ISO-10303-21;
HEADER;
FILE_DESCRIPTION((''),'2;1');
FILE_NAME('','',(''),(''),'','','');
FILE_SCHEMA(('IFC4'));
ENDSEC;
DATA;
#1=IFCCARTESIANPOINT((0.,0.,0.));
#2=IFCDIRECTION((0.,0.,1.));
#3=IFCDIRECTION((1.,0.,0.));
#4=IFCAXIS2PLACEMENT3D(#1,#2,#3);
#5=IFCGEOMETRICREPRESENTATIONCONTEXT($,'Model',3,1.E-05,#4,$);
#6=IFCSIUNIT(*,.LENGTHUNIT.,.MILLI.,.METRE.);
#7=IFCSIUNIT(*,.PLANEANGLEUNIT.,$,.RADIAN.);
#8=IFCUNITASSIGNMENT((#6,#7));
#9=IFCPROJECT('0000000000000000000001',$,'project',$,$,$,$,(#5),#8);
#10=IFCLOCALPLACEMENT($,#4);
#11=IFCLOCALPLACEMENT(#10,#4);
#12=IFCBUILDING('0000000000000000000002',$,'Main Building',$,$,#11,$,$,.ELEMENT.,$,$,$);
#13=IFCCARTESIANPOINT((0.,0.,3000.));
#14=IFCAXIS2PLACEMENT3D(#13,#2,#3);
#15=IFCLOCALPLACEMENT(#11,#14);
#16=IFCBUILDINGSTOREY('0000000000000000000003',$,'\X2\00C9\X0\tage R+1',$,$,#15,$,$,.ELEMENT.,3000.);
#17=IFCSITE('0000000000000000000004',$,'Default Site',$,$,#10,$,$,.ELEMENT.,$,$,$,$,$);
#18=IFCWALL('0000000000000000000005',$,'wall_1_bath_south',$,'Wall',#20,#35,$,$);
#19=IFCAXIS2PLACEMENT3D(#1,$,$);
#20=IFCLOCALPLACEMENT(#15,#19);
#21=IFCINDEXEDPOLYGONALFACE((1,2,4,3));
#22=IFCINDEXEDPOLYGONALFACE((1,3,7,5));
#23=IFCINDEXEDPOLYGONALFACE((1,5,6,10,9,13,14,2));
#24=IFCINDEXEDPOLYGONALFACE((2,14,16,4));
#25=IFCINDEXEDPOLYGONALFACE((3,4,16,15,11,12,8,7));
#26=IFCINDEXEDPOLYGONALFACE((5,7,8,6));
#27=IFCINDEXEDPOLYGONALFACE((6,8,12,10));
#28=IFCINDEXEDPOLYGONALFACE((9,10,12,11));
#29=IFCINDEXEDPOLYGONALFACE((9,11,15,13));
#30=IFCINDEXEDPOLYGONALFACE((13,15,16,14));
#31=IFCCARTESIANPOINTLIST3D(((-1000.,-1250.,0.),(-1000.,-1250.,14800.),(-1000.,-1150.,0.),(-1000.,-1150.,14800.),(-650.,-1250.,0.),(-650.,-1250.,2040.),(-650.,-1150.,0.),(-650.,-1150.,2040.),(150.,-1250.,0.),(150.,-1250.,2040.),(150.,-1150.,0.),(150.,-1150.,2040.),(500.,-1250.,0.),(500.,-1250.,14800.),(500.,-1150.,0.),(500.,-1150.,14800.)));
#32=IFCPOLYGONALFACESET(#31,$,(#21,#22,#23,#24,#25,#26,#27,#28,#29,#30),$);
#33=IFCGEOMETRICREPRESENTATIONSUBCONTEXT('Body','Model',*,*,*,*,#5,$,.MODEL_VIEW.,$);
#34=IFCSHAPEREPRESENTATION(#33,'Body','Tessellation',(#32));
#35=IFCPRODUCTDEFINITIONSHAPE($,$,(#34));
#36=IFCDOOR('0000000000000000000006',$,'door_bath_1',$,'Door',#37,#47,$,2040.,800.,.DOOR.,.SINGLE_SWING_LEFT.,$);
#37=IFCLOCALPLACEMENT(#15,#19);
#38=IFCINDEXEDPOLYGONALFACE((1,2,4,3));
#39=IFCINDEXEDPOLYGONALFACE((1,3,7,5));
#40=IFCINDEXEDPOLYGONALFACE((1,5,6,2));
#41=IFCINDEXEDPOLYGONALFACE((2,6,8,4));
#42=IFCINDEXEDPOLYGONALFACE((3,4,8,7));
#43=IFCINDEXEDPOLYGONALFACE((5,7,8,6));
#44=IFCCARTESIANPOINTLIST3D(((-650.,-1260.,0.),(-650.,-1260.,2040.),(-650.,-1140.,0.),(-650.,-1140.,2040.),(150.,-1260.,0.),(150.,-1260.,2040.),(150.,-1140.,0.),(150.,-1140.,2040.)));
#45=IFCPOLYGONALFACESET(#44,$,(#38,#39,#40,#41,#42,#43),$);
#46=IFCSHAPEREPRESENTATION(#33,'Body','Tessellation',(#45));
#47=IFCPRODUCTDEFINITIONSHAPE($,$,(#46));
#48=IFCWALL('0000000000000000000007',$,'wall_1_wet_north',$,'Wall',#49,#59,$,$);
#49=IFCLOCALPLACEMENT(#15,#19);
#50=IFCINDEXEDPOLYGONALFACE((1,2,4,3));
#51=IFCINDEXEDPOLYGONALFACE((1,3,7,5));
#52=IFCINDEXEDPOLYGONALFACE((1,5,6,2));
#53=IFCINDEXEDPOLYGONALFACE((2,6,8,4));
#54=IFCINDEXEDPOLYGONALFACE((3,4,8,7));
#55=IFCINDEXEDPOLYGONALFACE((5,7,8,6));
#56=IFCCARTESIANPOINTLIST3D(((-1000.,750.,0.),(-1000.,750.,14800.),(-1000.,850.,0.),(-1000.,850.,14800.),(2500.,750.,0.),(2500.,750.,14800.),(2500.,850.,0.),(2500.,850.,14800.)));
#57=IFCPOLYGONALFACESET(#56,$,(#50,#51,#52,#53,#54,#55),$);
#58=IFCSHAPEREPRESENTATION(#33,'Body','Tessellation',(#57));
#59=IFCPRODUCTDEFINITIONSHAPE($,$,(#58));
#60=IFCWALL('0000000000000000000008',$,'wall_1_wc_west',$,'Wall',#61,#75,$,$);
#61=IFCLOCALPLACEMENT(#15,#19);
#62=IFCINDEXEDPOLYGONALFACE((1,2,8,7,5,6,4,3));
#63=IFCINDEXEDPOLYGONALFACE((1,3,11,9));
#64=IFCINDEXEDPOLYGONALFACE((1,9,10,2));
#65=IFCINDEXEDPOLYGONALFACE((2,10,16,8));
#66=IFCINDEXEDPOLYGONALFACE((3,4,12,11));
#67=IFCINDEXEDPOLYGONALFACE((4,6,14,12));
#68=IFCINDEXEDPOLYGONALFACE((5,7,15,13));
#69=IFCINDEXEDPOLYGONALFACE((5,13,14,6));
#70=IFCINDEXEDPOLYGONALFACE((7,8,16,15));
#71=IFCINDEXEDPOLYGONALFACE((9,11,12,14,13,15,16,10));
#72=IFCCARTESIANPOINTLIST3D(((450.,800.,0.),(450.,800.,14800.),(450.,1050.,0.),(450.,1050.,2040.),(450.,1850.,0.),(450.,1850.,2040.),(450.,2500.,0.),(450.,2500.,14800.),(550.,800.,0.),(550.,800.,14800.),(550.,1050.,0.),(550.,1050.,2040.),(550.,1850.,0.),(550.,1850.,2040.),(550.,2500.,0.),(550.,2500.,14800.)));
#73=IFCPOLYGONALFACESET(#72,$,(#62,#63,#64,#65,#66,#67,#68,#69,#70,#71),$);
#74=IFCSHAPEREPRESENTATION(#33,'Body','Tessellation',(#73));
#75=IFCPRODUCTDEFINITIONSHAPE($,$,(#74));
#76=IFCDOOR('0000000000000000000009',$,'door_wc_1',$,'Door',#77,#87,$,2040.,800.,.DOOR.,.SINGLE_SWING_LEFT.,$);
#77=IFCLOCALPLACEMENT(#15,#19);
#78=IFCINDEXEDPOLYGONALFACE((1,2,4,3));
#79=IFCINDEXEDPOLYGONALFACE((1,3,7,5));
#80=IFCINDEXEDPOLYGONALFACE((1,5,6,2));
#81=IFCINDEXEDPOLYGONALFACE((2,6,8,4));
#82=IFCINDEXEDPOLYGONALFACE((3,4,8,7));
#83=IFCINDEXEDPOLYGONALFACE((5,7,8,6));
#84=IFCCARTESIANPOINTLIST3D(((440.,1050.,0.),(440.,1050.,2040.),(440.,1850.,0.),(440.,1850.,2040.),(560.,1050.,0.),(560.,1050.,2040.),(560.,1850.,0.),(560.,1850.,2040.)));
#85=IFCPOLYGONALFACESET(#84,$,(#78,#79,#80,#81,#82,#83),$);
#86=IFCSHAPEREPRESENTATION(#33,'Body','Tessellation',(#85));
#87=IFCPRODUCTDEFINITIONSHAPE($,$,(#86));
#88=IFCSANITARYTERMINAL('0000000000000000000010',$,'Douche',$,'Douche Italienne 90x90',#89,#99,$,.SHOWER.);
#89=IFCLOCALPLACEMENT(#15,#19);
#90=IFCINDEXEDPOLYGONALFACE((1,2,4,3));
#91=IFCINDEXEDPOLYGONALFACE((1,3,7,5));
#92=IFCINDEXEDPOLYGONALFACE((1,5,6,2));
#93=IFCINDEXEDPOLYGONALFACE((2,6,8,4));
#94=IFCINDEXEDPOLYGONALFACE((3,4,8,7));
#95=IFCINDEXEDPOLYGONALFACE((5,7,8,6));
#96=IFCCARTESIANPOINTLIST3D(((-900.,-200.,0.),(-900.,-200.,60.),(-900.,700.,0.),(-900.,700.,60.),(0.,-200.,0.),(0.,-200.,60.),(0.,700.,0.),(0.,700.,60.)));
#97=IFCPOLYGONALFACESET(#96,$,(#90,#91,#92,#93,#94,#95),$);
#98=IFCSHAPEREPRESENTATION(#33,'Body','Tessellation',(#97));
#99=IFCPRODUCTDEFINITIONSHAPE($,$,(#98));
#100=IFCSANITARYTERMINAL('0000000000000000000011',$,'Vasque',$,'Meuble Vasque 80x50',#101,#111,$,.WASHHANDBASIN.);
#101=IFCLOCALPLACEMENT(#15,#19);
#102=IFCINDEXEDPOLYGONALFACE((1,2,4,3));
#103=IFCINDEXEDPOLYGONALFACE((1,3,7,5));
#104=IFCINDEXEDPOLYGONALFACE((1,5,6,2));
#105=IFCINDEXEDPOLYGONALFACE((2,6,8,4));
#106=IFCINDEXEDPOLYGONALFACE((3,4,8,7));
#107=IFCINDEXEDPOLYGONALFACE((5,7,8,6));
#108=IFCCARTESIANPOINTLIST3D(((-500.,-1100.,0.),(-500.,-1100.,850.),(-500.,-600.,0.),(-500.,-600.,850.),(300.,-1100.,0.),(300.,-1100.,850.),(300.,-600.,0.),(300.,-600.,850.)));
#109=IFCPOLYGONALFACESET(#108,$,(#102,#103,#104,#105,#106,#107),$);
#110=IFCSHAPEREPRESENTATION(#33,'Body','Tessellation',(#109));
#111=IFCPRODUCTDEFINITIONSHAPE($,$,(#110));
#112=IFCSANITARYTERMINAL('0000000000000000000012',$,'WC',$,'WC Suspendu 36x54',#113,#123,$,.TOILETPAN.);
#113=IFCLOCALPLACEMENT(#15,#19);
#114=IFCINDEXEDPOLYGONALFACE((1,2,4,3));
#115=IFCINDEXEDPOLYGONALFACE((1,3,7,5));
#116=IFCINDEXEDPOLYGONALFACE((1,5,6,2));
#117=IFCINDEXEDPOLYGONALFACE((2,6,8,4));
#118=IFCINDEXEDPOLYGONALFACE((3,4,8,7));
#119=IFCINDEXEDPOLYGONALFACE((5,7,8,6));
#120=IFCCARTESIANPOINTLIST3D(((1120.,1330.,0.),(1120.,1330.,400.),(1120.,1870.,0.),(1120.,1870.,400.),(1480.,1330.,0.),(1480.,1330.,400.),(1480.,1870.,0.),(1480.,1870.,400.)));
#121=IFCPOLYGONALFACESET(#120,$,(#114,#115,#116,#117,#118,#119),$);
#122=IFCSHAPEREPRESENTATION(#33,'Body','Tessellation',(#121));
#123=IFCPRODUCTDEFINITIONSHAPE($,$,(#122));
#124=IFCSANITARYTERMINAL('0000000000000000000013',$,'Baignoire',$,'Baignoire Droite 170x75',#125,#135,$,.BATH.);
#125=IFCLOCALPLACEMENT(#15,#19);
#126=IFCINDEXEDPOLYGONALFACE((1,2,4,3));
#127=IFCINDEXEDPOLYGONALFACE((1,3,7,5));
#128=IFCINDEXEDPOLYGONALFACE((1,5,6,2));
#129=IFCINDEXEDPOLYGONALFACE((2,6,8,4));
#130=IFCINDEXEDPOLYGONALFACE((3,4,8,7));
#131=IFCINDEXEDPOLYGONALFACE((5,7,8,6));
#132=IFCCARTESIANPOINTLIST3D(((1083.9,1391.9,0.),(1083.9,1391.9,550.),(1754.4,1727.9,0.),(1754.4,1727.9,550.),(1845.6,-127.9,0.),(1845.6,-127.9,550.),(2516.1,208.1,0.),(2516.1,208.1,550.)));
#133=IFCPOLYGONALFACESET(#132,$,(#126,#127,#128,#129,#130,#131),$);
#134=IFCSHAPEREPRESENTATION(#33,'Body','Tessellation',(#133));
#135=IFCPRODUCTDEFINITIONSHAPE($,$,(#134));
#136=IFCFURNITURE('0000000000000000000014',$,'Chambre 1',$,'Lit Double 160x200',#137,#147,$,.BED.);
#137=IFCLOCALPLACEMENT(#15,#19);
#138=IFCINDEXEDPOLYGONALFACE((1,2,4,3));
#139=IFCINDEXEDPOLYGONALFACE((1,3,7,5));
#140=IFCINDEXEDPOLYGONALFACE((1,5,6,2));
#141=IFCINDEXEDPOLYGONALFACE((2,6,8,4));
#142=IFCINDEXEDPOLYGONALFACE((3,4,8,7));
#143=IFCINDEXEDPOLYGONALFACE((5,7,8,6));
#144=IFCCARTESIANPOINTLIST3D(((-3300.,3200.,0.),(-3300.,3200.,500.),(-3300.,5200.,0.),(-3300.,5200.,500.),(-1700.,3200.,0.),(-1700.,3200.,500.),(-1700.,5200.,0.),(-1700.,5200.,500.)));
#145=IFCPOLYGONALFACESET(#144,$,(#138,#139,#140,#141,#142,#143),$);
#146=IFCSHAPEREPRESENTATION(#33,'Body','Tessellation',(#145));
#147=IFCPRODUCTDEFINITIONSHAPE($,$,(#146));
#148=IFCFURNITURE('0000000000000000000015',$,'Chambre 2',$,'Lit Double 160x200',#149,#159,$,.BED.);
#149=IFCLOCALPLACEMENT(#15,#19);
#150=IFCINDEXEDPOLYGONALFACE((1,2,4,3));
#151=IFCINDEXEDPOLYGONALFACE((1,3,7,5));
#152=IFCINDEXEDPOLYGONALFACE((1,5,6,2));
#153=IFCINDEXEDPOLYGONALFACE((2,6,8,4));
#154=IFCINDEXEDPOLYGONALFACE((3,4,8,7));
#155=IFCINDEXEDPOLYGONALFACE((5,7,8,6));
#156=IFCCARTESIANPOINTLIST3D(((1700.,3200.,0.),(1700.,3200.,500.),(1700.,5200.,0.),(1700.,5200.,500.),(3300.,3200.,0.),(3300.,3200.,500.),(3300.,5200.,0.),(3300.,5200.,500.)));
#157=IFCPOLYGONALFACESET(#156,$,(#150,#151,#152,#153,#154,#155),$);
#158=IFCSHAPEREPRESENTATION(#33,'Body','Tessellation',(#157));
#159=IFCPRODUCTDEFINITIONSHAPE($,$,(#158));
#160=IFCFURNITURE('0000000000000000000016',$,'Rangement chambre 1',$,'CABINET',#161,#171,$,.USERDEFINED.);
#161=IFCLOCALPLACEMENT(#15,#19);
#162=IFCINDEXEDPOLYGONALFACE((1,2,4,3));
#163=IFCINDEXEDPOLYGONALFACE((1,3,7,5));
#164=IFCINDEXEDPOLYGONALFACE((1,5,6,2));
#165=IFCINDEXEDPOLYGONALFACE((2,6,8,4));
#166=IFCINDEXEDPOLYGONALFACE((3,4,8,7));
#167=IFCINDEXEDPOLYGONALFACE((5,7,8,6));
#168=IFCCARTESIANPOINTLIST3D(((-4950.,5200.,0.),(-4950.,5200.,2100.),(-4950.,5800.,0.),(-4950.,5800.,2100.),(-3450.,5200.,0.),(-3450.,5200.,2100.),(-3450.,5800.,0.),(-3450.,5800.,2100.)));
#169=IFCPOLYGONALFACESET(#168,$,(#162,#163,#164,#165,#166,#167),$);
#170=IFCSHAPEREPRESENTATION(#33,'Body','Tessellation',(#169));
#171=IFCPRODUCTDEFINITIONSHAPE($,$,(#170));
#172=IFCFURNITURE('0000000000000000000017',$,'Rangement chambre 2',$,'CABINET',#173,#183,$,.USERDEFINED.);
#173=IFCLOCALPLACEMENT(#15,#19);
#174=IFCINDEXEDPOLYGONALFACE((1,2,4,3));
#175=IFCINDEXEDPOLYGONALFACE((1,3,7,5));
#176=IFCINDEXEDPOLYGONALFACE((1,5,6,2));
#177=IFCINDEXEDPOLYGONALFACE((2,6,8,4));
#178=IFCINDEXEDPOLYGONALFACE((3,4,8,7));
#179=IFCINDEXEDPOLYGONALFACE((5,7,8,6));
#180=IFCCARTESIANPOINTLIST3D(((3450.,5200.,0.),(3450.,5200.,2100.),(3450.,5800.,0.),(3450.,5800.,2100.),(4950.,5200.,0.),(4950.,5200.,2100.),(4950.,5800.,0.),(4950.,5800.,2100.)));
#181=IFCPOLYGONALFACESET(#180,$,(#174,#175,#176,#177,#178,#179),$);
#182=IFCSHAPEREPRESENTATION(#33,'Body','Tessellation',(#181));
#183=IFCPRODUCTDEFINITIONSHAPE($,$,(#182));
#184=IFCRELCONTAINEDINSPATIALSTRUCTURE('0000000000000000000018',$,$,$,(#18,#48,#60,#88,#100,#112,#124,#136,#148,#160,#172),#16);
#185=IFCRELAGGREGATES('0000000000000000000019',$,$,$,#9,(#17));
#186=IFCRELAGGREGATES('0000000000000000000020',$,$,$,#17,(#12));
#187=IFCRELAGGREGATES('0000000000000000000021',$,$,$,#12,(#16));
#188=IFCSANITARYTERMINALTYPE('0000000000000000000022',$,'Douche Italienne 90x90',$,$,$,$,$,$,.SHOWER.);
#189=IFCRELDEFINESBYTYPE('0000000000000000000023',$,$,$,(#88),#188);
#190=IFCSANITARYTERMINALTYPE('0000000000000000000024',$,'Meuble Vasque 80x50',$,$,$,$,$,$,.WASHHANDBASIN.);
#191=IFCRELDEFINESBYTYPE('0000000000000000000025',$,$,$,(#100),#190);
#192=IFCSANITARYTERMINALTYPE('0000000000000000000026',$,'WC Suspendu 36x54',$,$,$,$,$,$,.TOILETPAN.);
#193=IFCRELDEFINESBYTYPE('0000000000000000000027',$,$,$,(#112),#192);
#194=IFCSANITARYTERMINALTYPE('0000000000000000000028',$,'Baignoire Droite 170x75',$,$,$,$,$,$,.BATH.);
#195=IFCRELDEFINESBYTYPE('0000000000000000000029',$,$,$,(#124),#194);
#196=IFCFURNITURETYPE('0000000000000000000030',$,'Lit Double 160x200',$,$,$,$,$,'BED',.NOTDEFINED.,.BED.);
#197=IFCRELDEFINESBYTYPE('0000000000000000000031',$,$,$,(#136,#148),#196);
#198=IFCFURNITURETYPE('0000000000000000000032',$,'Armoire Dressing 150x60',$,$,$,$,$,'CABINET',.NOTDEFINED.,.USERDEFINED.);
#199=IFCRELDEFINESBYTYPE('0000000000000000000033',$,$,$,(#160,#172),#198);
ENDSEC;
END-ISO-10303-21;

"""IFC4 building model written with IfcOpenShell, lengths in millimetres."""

from ifc_helpers import new_model, si_unit, frame, origin_with_axes, place, context, subcontext, project, spatial, polyline, outline, extrude, type_object, element, fill, save


model = new_model("IFC4")

# Units and contexts
model_context = context("Model", 3, precision=1e-05, world=origin_with_axes())
body_context = subcontext(model_context, "Body", "Model", "MODEL_VIEW")
ifc_project = project(units=[si_unit("LENGTHUNIT", "METRE", prefix="MILLI"), si_unit("PLANEANGLEUNIT", "RADIAN")], contexts=[model_context])

# Site, building, storey
site_placement = place(None, origin_with_axes())
site = spatial("IfcSite", under=ifc_project, at=site_placement, Name="Default Site", CompositionType="ELEMENT")
building_placement = place(site_placement, origin_with_axes())
building = spatial("IfcBuilding", under=site, at=building_placement, Name="Main Building", CompositionType="ELEMENT")
storey_placement = place(building_placement, frame((0.0, 0.0, 3000.0), z_axis=(0.0, 0.0, 1.0), x_axis=(1.0, 0.0, 0.0)))
storey = spatial("IfcBuildingStorey", under=building, at=storey_placement, Name="Étage R+1", CompositionType="ELEMENT", Elevation=3000.0)

# Wall, opening, door
wall_1_placement = place(storey_placement, frame((-1000.0, -1200.0, 0.0), z_axis=(0.0, 0.0, 1.0), x_axis=(1.0, 0.0, 0.0)))
wall_1 = element("IfcWall", 1, at=wall_1_placement, inside=storey, Name="wall_1_bath_south", ObjectType="Wall", context=body_context, shape_type="SweptSolid", body=[
    extrude(outline(polyline([(0.0, -50.0), (1500.0, -50.0), (1500.0, 50.0), (0.0, 50.0), (0.0, -50.0)])), origin_with_axes(), (0.0, 0.0, 1.0), 14800.0),
])
placement_1 = place(wall_1_placement, frame((350.0, 0.0, 0.0), z_axis=(0.0, 0.0, 1.0), x_axis=(1.0, 0.0, 0.0)))
opening_1 = element("IfcOpeningElement", 2, at=placement_1, cuts=wall_1, PredefinedType="OPENING", context=body_context, shape_type="SweptSolid", body=[
    extrude(outline(polyline([(0.0, -60.0), (800.0, -60.0), (800.0, 60.0), (0.0, 60.0), (0.0, -60.0)])), origin_with_axes(), (0.0, 0.0, 1.0), 2040.0),
])
door_1 = element("IfcDoor", 3, at=placement_1, Name="door_bath_1", ObjectType="Door", OperationType="SINGLE_SWING_LEFT", OverallHeight=2040.0, OverallWidth=800.0, PredefinedType="DOOR", context=body_context, shape_type="SweptSolid", body=[
    extrude(outline(polyline([(0.0, -60.0), (800.0, -60.0), (800.0, 60.0), (0.0, 60.0), (0.0, -60.0)])), origin_with_axes(), (0.0, 0.0, 1.0), 2040.0),
])
fill(opening_1, door_1)

# Wall
wall_2_placement = place(storey_placement, frame((-1000.0, 800.0, 0.0), z_axis=(0.0, 0.0, 1.0), x_axis=(1.0, 0.0, 0.0)))
element("IfcWall", 4, at=wall_2_placement, inside=storey, Name="wall_1_wet_north", ObjectType="Wall", context=body_context, shape_type="SweptSolid", body=[
    extrude(outline(polyline([(0.0, -50.0), (3500.0, -50.0), (3500.0, 50.0), (0.0, 50.0), (0.0, -50.0)])), origin_with_axes(), (0.0, 0.0, 1.0), 14800.0),
])

# Wall, opening, door
wall_3_placement = place(storey_placement, frame((500.0, 800.0, 0.0), z_axis=(0.0, 0.0, 1.0), x_axis=(0.0, 1.0, 0.0)))
wall_3 = element("IfcWall", 5, at=wall_3_placement, inside=storey, Name="wall_1_wc_west", ObjectType="Wall", context=body_context, shape_type="SweptSolid", body=[
    extrude(outline(polyline([(0.0, -50.0), (1700.0, -50.0), (1700.0, 50.0), (0.0, 50.0), (0.0, -50.0)])), origin_with_axes(), (0.0, 0.0, 1.0), 14800.0),
])
placement_2 = place(wall_3_placement, frame((250.0, 0.0, 0.0), z_axis=(0.0, 0.0, 1.0), x_axis=(1.0, 0.0, 0.0)))
opening_2 = element("IfcOpeningElement", 6, at=placement_2, cuts=wall_3, PredefinedType="OPENING", context=body_context, shape_type="SweptSolid", body=[
    extrude(outline(polyline([(0.0, -60.0), (800.0, -60.0), (800.0, 60.0), (0.0, 60.0), (0.0, -60.0)])), origin_with_axes(), (0.0, 0.0, 1.0), 2040.0),
])
door_2 = element("IfcDoor", 7, at=placement_2, Name="door_wc_1", ObjectType="Door", OperationType="SINGLE_SWING_LEFT", OverallHeight=2040.0, OverallWidth=800.0, PredefinedType="DOOR", context=body_context, shape_type="SweptSolid", body=[
    extrude(outline(polyline([(0.0, -60.0), (800.0, -60.0), (800.0, 60.0), (0.0, 60.0), (0.0, -60.0)])), origin_with_axes(), (0.0, 0.0, 1.0), 2040.0),
])
fill(opening_2, door_2)

# Sanitary terminals
sanitary_terminal_type_1 = type_object("IfcSanitaryTerminalType", Name="Douche Italienne 90x90", PredefinedType="SHOWER")
sanitary_terminal_1_placement = place(storey_placement, frame((-450.0, 250.0, 0.0), z_axis=(0.0, 0.0, 1.0), x_axis=(1.0, 0.0, 0.0)))
element("IfcSanitaryTerminal", 8, at=sanitary_terminal_1_placement, inside=storey, type_object=sanitary_terminal_type_1, Name="Douche", ObjectType="Douche Italienne 90x90", PredefinedType="SHOWER", context=body_context, shape_type="SweptSolid", body=[
    extrude(outline(polyline([(-450.0, -450.0), (450.0, -450.0), (450.0, 450.0), (-450.0, 450.0), (-450.0, -450.0)])), origin_with_axes(), (0.0, 0.0, 1.0), 60.0),
])
sanitary_terminal_type_2 = type_object("IfcSanitaryTerminalType", Name="Meuble Vasque 80x50", PredefinedType="WASHHANDBASIN")
sanitary_terminal_2_placement = place(storey_placement, frame((-100.0, -850.0, 0.0), z_axis=(0.0, 0.0, 1.0), x_axis=(1.0, 0.0, 0.0)))
element("IfcSanitaryTerminal", 9, at=sanitary_terminal_2_placement, inside=storey, type_object=sanitary_terminal_type_2, Name="Vasque", ObjectType="Meuble Vasque 80x50", PredefinedType="WASHHANDBASIN", context=body_context, shape_type="SweptSolid", body=[
    extrude(outline(polyline([(-400.0, -250.0), (400.0, -250.0), (400.0, 250.0), (-400.0, 250.0), (-400.0, -250.0)])), origin_with_axes(), (0.0, 0.0, 1.0), 850.0),
])
sanitary_terminal_type_3 = type_object("IfcSanitaryTerminalType", Name="WC Suspendu 36x54", PredefinedType="TOILETPAN")
sanitary_terminal_3_placement = place(storey_placement, frame((1300.0, 1600.0, 0.0), z_axis=(0.0, 0.0, 1.0), x_axis=(1.0, 0.0, 0.0)))
element("IfcSanitaryTerminal", 10, at=sanitary_terminal_3_placement, inside=storey, type_object=sanitary_terminal_type_3, Name="WC", ObjectType="WC Suspendu 36x54", PredefinedType="TOILETPAN", context=body_context, shape_type="SweptSolid", body=[
    extrude(outline(polyline([(-180.0, -270.0), (180.0, -270.0), (180.0, 270.0), (-180.0, 270.0), (-180.0, -270.0)])), origin_with_axes(), (0.0, 0.0, 1.0), 400.0),
])
sanitary_terminal_type_4 = type_object("IfcSanitaryTerminalType", Name="Baignoire Droite 170x75", PredefinedType="BATH")
sanitary_terminal_4_placement = place(storey_placement, frame((1800.0, 800.0, 0.0), z_axis=(0.0, 0.0, 1.0), x_axis=(-0.448074, 0.893997, 0.0)))
element("IfcSanitaryTerminal", 11, at=sanitary_terminal_4_placement, inside=storey, type_object=sanitary_terminal_type_4, Name="Baignoire", ObjectType="Baignoire Droite 170x75", PredefinedType="BATH", context=body_context, shape_type="SweptSolid", body=[
    extrude(outline(polyline([(-850.0, -375.0), (850.0, -375.0), (850.0, 375.0), (-850.0, 375.0), (-850.0, -375.0)])), origin_with_axes(), (0.0, 0.0, 1.0), 550.0),
])

# Furniture
furniture_type_1 = type_object("IfcFurnitureType", Name="Lit Double 160x200", ElementType="BED", AssemblyPlace="NOTDEFINED", PredefinedType="BED")
for number, where, z_axis, x_axis, name in (
    (12, (-2500.0, 4200.0, 0.0), (0.0, 0.0, 1.0), (1.0, 0.0, 0.0), "Chambre 1"),
    (13, (2500.0, 4200.0, 0.0), (0.0, 0.0, 1.0), (1.0, 0.0, 0.0), "Chambre 2"),
):
    element("IfcFurniture", number, at=place(storey_placement, frame(where, z_axis=z_axis, x_axis=x_axis)), inside=storey, type_object=furniture_type_1, Name=name, ObjectType="Lit Double 160x200", PredefinedType="BED", context=body_context, shape_type="SweptSolid", body=[
        extrude(outline(polyline([(-800.0, -1000.0), (800.0, -1000.0), (800.0, 1000.0), (-800.0, 1000.0), (-800.0, -1000.0)])), origin_with_axes(), (0.0, 0.0, 1.0), 500.0),
    ])
furniture_type_2 = type_object("IfcFurnitureType", Name="Armoire Dressing 150x60", ElementType="CABINET", AssemblyPlace="NOTDEFINED", PredefinedType="USERDEFINED")
for number, where, z_axis, x_axis, name in (
    (14, (-4200.0, 5500.0, 0.0), (0.0, 0.0, 1.0), (1.0, 0.0, 0.0), "Rangement chambre 1"),
    (15, (4200.0, 5500.0, 0.0), (0.0, 0.0, 1.0), (1.0, 0.0, 0.0), "Rangement chambre 2"),
):
    element("IfcFurniture", number, at=place(storey_placement, frame(where, z_axis=z_axis, x_axis=x_axis)), inside=storey, type_object=furniture_type_2, Name=name, ObjectType="CABINET", PredefinedType="USERDEFINED", context=body_context, shape_type="SweptSolid", body=[
        extrude(outline(polyline([(-750.0, -300.0), (750.0, -300.0), (750.0, 300.0), (-750.0, 300.0), (-750.0, -300.0)])), origin_with_axes(), (0.0, 0.0, 1.0), 2100.0),
    ])

save(model, "model.ifc")
